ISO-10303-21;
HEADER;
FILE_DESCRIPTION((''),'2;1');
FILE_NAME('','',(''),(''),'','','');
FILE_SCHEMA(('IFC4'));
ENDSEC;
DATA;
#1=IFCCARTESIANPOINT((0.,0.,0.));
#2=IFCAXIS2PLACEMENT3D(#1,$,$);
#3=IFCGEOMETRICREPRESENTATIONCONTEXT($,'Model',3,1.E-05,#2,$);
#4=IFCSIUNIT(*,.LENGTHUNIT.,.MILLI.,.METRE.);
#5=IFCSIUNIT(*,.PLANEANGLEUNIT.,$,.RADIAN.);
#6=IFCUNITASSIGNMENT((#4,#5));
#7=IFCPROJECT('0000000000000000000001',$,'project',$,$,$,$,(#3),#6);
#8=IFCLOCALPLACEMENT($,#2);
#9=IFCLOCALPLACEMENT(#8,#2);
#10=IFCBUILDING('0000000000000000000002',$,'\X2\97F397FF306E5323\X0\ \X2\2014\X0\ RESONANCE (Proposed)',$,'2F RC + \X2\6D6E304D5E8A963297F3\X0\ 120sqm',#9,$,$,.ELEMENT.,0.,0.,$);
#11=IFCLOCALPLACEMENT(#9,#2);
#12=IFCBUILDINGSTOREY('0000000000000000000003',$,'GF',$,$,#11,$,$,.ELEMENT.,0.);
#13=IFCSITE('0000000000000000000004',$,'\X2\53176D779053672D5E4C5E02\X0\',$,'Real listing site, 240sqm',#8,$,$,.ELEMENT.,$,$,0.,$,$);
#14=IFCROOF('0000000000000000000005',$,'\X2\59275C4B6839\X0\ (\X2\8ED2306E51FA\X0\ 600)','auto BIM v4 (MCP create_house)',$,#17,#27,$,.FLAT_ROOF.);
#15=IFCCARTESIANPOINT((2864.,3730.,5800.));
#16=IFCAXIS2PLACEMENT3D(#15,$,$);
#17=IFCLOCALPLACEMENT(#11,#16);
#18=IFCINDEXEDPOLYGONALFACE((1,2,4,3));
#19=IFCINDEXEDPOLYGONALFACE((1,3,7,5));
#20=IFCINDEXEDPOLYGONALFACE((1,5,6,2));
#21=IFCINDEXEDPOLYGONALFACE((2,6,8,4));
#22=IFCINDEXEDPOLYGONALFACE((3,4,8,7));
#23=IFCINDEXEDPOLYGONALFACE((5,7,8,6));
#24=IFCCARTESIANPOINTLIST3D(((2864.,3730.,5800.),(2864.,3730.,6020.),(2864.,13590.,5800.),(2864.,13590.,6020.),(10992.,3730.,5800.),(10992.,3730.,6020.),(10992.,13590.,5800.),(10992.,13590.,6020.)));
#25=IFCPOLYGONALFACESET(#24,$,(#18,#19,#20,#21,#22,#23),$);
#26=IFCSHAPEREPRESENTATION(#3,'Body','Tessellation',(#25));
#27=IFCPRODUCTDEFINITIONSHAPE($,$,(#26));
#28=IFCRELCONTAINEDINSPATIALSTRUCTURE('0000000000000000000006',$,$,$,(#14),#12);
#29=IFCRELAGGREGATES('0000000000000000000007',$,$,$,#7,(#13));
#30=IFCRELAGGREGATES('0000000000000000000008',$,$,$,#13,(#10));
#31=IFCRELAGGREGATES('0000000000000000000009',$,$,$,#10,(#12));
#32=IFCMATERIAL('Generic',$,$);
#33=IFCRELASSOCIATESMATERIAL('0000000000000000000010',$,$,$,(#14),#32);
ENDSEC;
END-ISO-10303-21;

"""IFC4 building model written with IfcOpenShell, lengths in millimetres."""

from ifc_helpers import new_model, si_unit, frame, frame_2d, origin, place, context, project, spatial, rectangle, extrude, material, element, save


model = new_model("IFC4")

# Units and contexts
model_context = context("Model", 3, precision=1e-05, world=origin())
ifc_project = project(units=[si_unit("LENGTHUNIT", "METRE", prefix="MILLI"), si_unit("PLANEANGLEUNIT", "RADIAN")], contexts=[model_context])

# Site, building, storey
site_placement = place(None, origin())
site = spatial("IfcSite", under=ifc_project, at=site_placement, Name="北海道札幌市", ObjectType="Real listing site, 240sqm", CompositionType="ELEMENT", RefElevation=0.0)
building_placement = place(site_placement, origin())
building = spatial("IfcBuilding", under=site, at=building_placement, Name="音響の匣 — RESONANCE (Proposed)", ObjectType="2F RC + 浮き床防音 120sqm", CompositionType="ELEMENT", ElevationOfRefHeight=0.0, ElevationOfTerrain=0.0)
storey_placement = place(building_placement, origin())
storey = spatial("IfcBuildingStorey", under=building, at=storey_placement, Name="GF", CompositionType="ELEMENT", Elevation=0.0)

# Shared definitions
ifc_material = material(Name="Generic")

# Roof
roof_placement = place(storey_placement, frame((2864.0, 3730.0, 5800.0)))
element("IfcRoof", 1, at=roof_placement, inside=storey, material=ifc_material, Name="大屋根 (軒の出 600)", Description="auto BIM v4 (MCP create_house)", PredefinedType="FLAT_ROOF", context=model_context, shape_type="SweptSolid", body=[
    extrude(rectangle(XDim=8128.0, YDim=9860.0, at=frame_2d((4064.0, 4930.0))), frame((2864.0, 3730.0, 5800.0)), (0.0, 0.0, 1.0), 220.0),
])

save(model, "model.ifc")
